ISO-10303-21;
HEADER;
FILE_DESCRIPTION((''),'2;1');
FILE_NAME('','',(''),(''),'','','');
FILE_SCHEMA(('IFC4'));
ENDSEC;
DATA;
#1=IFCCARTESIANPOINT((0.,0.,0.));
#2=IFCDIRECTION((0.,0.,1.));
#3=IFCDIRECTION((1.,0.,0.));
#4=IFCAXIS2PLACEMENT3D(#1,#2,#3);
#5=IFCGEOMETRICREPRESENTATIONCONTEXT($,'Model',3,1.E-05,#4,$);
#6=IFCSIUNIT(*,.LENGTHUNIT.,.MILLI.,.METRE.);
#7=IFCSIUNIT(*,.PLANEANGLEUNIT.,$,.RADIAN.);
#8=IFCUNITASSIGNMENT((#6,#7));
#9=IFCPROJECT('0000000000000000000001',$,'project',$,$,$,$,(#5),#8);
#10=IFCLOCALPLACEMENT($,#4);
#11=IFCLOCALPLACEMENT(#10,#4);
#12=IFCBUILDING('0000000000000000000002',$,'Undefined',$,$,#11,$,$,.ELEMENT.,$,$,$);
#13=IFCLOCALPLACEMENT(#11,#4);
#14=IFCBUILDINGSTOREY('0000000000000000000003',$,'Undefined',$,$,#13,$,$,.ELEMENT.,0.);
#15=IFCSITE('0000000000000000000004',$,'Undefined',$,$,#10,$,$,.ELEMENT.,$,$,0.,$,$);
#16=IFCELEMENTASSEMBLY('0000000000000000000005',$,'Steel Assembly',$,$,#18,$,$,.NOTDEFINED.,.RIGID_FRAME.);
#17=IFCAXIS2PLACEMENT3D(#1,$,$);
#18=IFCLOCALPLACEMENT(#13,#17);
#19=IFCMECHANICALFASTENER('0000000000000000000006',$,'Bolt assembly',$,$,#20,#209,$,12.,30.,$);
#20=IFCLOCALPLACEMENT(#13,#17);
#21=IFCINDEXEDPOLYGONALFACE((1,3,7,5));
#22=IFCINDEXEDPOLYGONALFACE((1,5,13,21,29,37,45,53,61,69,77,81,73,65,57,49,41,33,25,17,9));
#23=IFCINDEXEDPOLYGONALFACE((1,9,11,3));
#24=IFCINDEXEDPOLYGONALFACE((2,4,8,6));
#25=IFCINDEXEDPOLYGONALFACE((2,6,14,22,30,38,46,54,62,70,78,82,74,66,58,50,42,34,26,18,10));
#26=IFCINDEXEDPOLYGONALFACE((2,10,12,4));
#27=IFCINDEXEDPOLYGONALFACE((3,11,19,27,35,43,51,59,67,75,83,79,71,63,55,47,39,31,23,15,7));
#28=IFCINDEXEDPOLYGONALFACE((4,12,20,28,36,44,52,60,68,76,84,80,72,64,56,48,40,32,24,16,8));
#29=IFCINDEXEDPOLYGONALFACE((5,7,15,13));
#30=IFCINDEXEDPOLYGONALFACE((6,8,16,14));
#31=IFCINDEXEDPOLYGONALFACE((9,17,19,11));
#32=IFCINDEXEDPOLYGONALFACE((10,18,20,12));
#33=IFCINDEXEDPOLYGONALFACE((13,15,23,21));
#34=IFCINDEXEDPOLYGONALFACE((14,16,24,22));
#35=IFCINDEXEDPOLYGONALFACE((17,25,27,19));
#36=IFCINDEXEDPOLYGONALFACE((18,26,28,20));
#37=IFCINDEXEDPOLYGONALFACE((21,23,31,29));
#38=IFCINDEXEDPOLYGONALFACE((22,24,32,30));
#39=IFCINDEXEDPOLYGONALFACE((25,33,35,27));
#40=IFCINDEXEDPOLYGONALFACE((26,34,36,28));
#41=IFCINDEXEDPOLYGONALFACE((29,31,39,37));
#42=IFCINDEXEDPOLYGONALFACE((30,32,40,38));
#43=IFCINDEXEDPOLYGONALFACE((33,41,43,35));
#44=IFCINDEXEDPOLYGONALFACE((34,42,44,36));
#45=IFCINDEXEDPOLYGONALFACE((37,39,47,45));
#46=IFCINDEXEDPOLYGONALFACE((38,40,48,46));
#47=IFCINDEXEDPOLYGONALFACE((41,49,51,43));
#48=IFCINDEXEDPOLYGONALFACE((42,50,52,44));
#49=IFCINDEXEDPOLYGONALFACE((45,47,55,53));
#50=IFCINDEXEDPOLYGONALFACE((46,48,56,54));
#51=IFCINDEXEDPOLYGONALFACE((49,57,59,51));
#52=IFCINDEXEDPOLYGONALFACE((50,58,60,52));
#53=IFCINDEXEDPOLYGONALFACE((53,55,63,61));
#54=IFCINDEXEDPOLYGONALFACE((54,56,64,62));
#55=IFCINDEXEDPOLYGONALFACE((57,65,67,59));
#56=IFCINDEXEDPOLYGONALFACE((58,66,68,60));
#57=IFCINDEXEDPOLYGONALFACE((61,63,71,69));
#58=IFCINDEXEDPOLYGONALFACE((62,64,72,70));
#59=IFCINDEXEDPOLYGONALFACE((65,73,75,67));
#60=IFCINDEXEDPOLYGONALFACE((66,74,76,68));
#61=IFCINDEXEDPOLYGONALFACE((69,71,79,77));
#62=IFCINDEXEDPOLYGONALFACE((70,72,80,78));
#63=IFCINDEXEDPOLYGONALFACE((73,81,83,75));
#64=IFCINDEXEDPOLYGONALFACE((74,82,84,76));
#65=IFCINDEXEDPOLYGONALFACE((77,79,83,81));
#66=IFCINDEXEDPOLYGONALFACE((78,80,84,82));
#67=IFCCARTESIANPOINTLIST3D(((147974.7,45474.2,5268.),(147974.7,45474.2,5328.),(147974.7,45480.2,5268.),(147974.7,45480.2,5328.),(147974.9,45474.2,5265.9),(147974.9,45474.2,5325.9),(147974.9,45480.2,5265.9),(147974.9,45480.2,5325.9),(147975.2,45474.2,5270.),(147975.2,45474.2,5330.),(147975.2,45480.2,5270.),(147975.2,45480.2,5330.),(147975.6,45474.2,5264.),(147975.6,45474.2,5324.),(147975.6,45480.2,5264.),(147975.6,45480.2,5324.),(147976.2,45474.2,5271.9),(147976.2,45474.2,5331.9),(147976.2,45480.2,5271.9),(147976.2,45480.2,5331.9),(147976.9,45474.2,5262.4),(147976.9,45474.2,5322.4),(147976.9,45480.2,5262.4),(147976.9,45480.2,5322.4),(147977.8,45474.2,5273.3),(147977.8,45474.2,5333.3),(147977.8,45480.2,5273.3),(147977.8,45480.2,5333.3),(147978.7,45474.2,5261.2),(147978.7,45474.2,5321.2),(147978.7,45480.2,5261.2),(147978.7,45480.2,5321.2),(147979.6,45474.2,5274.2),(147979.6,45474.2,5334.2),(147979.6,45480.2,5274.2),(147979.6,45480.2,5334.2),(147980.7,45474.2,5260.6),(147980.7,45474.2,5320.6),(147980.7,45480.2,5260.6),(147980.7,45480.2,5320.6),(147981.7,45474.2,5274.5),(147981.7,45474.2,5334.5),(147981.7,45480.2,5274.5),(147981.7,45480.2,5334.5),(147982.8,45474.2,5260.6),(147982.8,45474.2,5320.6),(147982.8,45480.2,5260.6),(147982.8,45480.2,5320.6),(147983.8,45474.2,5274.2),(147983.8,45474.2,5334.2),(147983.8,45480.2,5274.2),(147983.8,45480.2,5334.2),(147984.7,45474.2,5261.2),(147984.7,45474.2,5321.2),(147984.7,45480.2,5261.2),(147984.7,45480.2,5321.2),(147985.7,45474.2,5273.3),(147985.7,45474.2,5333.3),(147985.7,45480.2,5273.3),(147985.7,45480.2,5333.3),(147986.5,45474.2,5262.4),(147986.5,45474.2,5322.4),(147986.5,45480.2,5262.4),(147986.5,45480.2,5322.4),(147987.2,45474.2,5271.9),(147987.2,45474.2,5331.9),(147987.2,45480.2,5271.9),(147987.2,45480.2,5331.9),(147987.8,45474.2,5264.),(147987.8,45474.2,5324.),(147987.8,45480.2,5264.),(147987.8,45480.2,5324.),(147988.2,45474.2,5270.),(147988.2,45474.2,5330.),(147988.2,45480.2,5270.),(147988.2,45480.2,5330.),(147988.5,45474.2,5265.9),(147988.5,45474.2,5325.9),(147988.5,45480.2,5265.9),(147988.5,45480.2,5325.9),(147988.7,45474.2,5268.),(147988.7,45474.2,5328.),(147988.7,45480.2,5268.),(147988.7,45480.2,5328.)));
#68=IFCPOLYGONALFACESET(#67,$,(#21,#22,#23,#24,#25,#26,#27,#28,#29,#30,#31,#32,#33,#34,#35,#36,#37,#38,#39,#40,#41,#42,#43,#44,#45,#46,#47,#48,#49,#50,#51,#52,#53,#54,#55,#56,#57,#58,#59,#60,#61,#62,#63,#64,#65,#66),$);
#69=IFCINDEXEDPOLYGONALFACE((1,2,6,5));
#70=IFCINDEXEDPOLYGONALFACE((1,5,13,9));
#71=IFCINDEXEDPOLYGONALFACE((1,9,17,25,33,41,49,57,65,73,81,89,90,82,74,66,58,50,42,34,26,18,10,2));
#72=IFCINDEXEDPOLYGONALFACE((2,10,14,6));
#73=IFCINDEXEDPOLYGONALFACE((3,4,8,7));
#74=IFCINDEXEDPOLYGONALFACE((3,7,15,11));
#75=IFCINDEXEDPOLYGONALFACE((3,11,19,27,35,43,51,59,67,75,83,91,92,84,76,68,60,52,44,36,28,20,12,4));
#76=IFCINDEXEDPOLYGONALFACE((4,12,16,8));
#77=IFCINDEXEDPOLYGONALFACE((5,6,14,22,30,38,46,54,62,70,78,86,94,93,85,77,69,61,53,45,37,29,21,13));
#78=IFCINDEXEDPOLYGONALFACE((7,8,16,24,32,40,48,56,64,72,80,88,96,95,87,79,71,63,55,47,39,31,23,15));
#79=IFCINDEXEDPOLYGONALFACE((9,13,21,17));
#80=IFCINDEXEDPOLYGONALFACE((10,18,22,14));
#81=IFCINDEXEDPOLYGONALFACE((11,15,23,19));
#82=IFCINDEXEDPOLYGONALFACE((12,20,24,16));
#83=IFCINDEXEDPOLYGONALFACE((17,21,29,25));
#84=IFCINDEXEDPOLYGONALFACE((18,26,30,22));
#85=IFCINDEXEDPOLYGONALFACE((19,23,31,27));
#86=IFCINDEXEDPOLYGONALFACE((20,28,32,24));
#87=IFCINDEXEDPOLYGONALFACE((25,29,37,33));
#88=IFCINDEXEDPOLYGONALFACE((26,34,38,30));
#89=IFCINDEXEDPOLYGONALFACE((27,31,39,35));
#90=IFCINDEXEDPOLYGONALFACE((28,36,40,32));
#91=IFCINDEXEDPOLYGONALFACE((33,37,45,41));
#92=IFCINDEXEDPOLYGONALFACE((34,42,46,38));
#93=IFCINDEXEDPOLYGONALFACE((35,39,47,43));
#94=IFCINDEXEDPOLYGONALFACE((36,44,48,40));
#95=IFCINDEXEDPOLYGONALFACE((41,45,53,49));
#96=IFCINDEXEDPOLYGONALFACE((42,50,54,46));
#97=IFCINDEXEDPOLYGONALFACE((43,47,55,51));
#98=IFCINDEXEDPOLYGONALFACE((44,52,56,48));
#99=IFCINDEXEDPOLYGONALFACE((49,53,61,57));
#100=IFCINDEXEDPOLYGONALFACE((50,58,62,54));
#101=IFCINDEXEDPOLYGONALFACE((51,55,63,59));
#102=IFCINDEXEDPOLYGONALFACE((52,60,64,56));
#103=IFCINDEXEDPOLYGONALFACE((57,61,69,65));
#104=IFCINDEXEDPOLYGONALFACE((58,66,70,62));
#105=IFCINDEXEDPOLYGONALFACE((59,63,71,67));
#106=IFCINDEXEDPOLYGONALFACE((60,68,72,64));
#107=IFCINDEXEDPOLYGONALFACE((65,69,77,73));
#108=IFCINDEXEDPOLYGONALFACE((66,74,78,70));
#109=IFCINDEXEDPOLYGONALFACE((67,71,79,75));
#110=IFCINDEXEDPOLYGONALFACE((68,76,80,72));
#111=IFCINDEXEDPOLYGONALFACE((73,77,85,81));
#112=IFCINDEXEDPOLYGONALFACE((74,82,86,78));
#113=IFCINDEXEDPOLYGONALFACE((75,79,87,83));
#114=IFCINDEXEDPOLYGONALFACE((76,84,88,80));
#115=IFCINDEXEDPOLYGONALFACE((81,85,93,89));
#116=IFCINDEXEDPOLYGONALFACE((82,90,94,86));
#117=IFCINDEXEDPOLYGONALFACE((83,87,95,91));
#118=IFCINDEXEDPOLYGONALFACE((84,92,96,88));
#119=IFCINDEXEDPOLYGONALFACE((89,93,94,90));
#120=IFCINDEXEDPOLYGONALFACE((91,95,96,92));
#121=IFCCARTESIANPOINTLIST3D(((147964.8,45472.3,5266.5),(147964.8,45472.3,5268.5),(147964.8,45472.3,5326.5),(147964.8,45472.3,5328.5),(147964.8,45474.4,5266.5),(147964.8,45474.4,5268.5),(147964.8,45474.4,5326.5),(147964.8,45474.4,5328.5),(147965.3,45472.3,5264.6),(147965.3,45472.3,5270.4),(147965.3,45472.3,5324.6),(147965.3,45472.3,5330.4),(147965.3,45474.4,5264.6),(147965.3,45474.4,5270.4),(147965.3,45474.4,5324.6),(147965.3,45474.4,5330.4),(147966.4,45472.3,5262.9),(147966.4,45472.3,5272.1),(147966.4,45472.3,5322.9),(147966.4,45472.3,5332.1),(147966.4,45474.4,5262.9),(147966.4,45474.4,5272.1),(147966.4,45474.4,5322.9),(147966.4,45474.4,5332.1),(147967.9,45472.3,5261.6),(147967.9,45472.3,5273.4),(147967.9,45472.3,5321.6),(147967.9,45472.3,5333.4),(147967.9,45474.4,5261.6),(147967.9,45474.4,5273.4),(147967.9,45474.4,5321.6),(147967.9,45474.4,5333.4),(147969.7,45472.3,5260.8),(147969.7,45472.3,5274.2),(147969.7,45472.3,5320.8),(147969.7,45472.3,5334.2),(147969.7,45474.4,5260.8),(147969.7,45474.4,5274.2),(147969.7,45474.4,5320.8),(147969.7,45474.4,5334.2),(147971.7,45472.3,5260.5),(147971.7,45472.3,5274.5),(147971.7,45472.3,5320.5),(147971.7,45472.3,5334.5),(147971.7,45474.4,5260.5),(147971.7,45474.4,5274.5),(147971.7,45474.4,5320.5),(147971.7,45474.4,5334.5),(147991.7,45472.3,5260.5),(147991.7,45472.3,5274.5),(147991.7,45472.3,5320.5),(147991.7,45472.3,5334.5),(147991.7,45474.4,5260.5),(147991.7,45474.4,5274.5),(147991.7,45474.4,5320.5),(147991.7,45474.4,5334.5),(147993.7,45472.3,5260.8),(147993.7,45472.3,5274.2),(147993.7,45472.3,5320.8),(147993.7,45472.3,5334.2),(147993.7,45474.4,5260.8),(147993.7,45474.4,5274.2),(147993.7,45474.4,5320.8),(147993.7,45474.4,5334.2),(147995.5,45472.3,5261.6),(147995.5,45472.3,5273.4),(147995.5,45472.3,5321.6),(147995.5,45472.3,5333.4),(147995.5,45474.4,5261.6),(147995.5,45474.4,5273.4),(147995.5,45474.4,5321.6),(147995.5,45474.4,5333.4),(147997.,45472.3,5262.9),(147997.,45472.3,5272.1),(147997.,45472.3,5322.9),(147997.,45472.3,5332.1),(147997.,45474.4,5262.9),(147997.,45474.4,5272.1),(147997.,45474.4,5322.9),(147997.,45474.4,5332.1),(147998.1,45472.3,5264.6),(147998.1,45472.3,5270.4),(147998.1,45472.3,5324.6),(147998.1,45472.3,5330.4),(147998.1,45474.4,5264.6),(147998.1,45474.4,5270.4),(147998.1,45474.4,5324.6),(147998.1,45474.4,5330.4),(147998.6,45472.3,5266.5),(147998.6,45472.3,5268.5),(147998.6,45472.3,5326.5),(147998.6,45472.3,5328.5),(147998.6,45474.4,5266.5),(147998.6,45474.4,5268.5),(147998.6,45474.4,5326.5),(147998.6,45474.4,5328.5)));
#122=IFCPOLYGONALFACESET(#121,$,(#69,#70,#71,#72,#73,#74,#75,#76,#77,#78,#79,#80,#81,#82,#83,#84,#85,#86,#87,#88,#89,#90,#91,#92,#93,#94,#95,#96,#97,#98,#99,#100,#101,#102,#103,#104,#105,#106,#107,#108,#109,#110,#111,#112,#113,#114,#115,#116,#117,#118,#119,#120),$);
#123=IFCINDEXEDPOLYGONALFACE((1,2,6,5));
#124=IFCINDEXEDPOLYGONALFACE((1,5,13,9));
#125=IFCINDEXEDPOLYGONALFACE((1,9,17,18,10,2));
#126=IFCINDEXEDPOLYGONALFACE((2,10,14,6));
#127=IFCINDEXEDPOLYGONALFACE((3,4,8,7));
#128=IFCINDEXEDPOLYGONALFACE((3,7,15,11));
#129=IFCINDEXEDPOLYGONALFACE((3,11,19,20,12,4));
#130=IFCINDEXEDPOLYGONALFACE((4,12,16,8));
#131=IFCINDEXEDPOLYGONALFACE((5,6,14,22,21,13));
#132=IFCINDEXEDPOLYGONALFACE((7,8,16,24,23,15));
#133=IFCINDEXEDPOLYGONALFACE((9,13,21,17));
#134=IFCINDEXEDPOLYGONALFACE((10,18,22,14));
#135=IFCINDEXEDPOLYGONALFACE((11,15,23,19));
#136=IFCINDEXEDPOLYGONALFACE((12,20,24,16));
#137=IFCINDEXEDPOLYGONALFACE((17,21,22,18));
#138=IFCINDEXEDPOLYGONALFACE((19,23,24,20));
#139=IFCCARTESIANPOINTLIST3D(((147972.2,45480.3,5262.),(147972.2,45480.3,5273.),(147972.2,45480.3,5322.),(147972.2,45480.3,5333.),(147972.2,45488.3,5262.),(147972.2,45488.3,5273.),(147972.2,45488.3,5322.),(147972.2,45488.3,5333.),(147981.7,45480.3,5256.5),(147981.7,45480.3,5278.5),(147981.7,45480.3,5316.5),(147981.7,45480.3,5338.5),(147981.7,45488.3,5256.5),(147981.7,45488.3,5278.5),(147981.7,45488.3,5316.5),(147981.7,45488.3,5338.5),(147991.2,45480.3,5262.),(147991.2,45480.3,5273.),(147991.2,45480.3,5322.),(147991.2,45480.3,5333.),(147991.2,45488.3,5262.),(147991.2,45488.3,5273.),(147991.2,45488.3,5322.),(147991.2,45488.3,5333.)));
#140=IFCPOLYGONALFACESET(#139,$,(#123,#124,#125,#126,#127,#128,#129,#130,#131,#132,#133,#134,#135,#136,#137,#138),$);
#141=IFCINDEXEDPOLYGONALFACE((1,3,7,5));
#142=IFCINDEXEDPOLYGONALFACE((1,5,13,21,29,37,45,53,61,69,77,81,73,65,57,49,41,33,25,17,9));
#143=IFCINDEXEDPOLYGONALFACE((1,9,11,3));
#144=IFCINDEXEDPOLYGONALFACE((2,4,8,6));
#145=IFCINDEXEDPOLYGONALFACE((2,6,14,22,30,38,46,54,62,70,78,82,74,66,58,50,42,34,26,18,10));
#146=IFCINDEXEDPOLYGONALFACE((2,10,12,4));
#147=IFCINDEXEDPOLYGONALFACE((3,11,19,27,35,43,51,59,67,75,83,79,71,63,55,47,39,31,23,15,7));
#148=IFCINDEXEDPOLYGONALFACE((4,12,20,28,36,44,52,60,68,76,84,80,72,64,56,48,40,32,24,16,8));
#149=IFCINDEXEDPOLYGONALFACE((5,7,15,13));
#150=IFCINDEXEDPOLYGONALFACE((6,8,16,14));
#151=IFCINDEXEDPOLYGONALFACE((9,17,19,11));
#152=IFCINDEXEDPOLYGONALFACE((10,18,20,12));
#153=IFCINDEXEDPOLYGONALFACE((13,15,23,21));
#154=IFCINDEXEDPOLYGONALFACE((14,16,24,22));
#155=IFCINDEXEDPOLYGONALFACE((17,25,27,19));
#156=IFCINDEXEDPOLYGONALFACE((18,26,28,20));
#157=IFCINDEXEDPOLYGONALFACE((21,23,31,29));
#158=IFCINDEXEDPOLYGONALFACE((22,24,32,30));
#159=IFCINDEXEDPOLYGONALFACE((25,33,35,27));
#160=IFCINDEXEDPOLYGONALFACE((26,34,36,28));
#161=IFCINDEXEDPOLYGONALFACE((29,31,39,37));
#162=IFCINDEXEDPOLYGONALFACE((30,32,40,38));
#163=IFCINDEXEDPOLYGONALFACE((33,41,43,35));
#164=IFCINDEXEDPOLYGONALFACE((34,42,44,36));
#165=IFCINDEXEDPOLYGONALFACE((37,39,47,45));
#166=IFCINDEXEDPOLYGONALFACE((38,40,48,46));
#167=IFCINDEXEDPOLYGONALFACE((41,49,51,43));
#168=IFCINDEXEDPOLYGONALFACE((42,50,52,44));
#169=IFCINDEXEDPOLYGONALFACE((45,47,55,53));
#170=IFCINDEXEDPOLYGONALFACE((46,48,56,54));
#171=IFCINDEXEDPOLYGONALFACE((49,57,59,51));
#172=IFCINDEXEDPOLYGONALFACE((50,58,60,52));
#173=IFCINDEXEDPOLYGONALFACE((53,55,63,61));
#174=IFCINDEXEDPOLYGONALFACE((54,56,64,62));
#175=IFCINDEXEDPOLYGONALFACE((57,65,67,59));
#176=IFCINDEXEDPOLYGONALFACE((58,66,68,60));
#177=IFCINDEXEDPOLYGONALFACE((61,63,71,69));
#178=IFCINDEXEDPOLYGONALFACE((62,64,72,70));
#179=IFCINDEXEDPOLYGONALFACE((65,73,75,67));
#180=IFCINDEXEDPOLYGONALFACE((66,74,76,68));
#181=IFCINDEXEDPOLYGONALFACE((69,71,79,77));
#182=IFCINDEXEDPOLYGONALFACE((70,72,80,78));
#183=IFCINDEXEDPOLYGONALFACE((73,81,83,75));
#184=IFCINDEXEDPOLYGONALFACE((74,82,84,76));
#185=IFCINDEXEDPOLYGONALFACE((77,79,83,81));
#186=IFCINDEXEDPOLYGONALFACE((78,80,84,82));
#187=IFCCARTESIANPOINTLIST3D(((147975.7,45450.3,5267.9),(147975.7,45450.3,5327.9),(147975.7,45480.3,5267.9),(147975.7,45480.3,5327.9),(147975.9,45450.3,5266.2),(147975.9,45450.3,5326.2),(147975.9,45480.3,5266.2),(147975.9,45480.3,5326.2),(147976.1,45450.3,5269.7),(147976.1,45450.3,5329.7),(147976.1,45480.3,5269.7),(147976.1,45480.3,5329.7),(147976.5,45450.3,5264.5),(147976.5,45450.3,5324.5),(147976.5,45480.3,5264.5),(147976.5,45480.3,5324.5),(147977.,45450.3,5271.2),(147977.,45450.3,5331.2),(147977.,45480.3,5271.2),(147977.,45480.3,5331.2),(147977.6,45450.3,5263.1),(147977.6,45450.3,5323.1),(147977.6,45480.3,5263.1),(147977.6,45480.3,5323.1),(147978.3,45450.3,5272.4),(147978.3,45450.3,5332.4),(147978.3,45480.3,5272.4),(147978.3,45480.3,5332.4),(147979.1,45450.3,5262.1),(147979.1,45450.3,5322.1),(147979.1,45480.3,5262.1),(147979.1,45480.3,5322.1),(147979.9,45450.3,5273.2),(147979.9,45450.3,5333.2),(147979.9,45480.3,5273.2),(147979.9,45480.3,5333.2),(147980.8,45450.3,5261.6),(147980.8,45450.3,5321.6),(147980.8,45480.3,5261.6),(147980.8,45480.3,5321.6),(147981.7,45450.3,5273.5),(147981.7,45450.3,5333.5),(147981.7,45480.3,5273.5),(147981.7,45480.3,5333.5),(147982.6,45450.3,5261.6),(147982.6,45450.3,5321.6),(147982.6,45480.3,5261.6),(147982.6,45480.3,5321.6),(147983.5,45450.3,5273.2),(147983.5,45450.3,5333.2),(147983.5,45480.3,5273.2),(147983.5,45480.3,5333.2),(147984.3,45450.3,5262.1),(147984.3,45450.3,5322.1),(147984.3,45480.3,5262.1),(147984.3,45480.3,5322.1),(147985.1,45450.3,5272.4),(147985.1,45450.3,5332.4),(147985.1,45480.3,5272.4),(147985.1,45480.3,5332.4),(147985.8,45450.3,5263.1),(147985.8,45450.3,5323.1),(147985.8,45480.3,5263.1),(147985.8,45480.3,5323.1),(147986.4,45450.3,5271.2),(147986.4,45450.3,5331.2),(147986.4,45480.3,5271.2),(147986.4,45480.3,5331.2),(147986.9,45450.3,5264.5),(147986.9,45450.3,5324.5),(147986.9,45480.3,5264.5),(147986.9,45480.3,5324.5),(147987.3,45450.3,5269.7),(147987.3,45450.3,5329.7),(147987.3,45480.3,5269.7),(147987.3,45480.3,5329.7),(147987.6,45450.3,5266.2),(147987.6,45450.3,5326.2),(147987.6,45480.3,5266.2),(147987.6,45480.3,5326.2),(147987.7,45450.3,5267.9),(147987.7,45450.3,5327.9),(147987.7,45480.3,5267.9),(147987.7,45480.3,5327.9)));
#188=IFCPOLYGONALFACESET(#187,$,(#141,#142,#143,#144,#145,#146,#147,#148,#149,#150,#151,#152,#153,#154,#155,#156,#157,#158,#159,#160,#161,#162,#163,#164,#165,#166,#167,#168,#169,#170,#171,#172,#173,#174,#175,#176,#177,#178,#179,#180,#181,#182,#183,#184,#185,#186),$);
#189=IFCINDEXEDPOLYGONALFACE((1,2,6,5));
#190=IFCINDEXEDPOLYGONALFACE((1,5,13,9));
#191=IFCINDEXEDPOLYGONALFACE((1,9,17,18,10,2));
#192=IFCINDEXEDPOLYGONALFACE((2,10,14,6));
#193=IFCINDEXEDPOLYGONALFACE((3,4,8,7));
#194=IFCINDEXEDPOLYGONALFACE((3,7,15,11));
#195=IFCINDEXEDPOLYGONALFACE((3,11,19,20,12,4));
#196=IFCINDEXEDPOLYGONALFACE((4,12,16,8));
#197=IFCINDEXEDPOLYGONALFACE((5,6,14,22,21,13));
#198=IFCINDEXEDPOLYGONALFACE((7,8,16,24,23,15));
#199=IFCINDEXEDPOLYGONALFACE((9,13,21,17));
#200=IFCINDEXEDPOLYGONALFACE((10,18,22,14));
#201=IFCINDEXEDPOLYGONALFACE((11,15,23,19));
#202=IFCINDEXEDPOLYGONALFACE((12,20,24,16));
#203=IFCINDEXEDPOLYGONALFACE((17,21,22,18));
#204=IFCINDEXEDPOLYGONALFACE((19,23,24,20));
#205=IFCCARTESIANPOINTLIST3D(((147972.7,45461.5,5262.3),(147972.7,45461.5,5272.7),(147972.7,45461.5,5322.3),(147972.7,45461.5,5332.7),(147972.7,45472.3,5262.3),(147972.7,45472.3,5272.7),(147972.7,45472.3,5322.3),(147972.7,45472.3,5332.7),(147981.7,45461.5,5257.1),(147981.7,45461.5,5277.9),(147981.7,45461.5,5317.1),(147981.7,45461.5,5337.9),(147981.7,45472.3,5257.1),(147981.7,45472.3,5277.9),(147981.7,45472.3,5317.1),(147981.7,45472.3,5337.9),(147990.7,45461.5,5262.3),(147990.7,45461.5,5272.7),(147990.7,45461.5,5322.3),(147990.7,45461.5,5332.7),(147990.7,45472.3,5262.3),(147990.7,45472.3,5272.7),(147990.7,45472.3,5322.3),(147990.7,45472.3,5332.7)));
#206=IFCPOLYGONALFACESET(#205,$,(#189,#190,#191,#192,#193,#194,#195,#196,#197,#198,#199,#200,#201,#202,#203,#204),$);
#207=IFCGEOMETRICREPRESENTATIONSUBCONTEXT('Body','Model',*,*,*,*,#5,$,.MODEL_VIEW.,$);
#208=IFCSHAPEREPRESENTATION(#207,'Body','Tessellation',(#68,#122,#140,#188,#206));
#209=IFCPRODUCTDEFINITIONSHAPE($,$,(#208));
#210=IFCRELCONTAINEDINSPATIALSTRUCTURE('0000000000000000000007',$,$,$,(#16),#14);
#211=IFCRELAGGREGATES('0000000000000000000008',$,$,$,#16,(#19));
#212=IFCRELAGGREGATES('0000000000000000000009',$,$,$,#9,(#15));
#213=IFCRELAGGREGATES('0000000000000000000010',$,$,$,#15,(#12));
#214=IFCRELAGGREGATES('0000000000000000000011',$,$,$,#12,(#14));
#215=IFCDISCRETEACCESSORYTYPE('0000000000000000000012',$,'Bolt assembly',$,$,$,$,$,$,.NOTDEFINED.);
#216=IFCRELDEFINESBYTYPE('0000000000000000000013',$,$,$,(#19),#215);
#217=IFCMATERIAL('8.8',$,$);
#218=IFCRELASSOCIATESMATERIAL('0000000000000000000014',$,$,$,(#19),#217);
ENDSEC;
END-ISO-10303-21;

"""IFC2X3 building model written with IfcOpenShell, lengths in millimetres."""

from ifc_helpers import new_model, si_unit, frame, frame_2d, origin_with_axes, origin_2d_with_axis, place, context, subcontext, project, spatial, polyline, circle_curve, parameter, trimmed, segment, composite_curve, circle, outline, extrude, source, transform, mapped, material, type_object, element, aggregate, save


model = new_model("IFC2X3")

# Units and contexts
model_context = context("Model", 3, precision=1e-05, world=origin_with_axes())
body_context = subcontext(model_context, "Body", "Model", "MODEL_VIEW")
ifc_project = project(units=[si_unit("LENGTHUNIT", "METRE", prefix="MILLI"), si_unit("PLANEANGLEUNIT", "RADIAN")], contexts=[model_context])

# Site, building, storey
site_placement = place(None, origin_with_axes())
site = spatial("IfcSite", under=ifc_project, at=site_placement, Name="Undefined", CompositionType="ELEMENT", RefElevation=0.0)
building_placement = place(site_placement, origin_with_axes())
building = spatial("IfcBuilding", under=site, at=building_placement, Name="Undefined", CompositionType="ELEMENT")
storey_placement = place(building_placement, origin_with_axes())
storey = spatial("IfcBuildingStorey", under=building, at=storey_placement, Name="Undefined", CompositionType="ELEMENT", Elevation=0.0)

# Shared definitions
discrete_accessory_type_1 = type_object("IfcDiscreteAccessoryType", Name="Bolt assembly")
ifc_material_1 = material(Name="8.8")

# Element assembly, mechanical fastener
assembly_1_placement = place(storey_placement, origin_with_axes())
assembly_1 = element("IfcElementAssembly", 1, at=assembly_1_placement, inside=storey, Name="Steel Assembly", AssemblyPlace="NOTDEFINED", PredefinedType="RIGID_FRAME")
shared_shape_1 = source(origin_with_axes(), body_context, "Body", "SweptSolid", [
    extrude(circle(Radius=7.0, at=origin_2d_with_axis()), frame((0.0, -2.9, 0.0), z_axis=(0.0, 1.0, 0.0), x_axis=(1.0, 0.0, 0.0)), (0.0, 0.0, 1.0), 6.0),
    extrude(outline(composite_curve([segment(polyline([(7.0, 10.0), (7.0, -10.0)]), True, "CONTINUOUS"), segment(trimmed(circle_curve(frame_2d((0.0, -10.0), x_axis=(1.0, 0.0)), 7.0), [parameter(0.0)], [parameter(3.1416)], False, "PARAMETER"), True, "CONTINUOUS"), segment(polyline([(-7.0, -10.0), (-7.0, 10.0)]), True, "CONTINUOUS"), segment(trimmed(circle_curve(frame_2d((0.0, 10.0), x_axis=(-1.0, 0.0)), 7.0), [parameter(0.0)], [parameter(3.1416)], False, "PARAMETER"), True, "DISCONTINUOUS")], self_intersect=False)), frame((0.0, 2.9, 0.0), z_axis=(0.0, 1.0, 0.0), x_axis=(1.0, 0.0, 0.0)), (0.0, 0.0, 1.0), 2.1),
    extrude(outline(polyline([(11.0, 0.0), (5.5, 9.5), (-5.5, 9.5), (-11.0, 0.0), (-5.5, -9.5), (5.5, -9.5), (11.0, 0.0)])), frame((0.0, -11.0, 0.0), z_axis=(0.0, 1.0, 0.0), x_axis=(1.0, 0.0, 0.0)), (0.0, 0.0, 1.0), 8.0),
    extrude(circle(Radius=6.0, at=origin_2d_with_axis()), frame((0.0, -3.0, 0.0), z_axis=(0.0, 1.0, 0.0), x_axis=(1.0, 0.0, 0.0)), (0.0, 0.0, 1.0), 30.0),
    extrude(outline(polyline([(10.4, 0.0), (5.2, 9.0), (-5.2, 9.0), (-10.4, 0.0), (-5.2, -9.0), (5.2, -9.0), (10.4, 0.0)])), frame((0.0, 5.0, 0.0), z_axis=(0.0, 1.0, 0.0), x_axis=(1.0, 0.0, 0.0)), (0.0, 0.0, 1.0), 10.8),
])
mechanical_fastener_1_placement = place(assembly_1_placement, frame((147936.7, 45477.3, 5222.5), z_axis=(1.0, 0.0, 0.0), x_axis=(0.0, 0.0, 1.0)))
mechanical_fastener_1 = element("IfcMechanicalFastener", 2, at=mechanical_fastener_1_placement, type_object=discrete_accessory_type_1, material=ifc_material_1, Name="Bolt assembly", NominalDiameter=12.0, NominalLength=30.0, context=body_context, shape_type="MappedRepresentation", body=[
    mapped(shared_shape_1, transform((45.0, 0.0, 45.0))),
    mapped(shared_shape_1, transform((105.0, 0.0, 45.0))),
])
aggregate(assembly_1, [mechanical_fastener_1])

save(model, "model.ifc")
